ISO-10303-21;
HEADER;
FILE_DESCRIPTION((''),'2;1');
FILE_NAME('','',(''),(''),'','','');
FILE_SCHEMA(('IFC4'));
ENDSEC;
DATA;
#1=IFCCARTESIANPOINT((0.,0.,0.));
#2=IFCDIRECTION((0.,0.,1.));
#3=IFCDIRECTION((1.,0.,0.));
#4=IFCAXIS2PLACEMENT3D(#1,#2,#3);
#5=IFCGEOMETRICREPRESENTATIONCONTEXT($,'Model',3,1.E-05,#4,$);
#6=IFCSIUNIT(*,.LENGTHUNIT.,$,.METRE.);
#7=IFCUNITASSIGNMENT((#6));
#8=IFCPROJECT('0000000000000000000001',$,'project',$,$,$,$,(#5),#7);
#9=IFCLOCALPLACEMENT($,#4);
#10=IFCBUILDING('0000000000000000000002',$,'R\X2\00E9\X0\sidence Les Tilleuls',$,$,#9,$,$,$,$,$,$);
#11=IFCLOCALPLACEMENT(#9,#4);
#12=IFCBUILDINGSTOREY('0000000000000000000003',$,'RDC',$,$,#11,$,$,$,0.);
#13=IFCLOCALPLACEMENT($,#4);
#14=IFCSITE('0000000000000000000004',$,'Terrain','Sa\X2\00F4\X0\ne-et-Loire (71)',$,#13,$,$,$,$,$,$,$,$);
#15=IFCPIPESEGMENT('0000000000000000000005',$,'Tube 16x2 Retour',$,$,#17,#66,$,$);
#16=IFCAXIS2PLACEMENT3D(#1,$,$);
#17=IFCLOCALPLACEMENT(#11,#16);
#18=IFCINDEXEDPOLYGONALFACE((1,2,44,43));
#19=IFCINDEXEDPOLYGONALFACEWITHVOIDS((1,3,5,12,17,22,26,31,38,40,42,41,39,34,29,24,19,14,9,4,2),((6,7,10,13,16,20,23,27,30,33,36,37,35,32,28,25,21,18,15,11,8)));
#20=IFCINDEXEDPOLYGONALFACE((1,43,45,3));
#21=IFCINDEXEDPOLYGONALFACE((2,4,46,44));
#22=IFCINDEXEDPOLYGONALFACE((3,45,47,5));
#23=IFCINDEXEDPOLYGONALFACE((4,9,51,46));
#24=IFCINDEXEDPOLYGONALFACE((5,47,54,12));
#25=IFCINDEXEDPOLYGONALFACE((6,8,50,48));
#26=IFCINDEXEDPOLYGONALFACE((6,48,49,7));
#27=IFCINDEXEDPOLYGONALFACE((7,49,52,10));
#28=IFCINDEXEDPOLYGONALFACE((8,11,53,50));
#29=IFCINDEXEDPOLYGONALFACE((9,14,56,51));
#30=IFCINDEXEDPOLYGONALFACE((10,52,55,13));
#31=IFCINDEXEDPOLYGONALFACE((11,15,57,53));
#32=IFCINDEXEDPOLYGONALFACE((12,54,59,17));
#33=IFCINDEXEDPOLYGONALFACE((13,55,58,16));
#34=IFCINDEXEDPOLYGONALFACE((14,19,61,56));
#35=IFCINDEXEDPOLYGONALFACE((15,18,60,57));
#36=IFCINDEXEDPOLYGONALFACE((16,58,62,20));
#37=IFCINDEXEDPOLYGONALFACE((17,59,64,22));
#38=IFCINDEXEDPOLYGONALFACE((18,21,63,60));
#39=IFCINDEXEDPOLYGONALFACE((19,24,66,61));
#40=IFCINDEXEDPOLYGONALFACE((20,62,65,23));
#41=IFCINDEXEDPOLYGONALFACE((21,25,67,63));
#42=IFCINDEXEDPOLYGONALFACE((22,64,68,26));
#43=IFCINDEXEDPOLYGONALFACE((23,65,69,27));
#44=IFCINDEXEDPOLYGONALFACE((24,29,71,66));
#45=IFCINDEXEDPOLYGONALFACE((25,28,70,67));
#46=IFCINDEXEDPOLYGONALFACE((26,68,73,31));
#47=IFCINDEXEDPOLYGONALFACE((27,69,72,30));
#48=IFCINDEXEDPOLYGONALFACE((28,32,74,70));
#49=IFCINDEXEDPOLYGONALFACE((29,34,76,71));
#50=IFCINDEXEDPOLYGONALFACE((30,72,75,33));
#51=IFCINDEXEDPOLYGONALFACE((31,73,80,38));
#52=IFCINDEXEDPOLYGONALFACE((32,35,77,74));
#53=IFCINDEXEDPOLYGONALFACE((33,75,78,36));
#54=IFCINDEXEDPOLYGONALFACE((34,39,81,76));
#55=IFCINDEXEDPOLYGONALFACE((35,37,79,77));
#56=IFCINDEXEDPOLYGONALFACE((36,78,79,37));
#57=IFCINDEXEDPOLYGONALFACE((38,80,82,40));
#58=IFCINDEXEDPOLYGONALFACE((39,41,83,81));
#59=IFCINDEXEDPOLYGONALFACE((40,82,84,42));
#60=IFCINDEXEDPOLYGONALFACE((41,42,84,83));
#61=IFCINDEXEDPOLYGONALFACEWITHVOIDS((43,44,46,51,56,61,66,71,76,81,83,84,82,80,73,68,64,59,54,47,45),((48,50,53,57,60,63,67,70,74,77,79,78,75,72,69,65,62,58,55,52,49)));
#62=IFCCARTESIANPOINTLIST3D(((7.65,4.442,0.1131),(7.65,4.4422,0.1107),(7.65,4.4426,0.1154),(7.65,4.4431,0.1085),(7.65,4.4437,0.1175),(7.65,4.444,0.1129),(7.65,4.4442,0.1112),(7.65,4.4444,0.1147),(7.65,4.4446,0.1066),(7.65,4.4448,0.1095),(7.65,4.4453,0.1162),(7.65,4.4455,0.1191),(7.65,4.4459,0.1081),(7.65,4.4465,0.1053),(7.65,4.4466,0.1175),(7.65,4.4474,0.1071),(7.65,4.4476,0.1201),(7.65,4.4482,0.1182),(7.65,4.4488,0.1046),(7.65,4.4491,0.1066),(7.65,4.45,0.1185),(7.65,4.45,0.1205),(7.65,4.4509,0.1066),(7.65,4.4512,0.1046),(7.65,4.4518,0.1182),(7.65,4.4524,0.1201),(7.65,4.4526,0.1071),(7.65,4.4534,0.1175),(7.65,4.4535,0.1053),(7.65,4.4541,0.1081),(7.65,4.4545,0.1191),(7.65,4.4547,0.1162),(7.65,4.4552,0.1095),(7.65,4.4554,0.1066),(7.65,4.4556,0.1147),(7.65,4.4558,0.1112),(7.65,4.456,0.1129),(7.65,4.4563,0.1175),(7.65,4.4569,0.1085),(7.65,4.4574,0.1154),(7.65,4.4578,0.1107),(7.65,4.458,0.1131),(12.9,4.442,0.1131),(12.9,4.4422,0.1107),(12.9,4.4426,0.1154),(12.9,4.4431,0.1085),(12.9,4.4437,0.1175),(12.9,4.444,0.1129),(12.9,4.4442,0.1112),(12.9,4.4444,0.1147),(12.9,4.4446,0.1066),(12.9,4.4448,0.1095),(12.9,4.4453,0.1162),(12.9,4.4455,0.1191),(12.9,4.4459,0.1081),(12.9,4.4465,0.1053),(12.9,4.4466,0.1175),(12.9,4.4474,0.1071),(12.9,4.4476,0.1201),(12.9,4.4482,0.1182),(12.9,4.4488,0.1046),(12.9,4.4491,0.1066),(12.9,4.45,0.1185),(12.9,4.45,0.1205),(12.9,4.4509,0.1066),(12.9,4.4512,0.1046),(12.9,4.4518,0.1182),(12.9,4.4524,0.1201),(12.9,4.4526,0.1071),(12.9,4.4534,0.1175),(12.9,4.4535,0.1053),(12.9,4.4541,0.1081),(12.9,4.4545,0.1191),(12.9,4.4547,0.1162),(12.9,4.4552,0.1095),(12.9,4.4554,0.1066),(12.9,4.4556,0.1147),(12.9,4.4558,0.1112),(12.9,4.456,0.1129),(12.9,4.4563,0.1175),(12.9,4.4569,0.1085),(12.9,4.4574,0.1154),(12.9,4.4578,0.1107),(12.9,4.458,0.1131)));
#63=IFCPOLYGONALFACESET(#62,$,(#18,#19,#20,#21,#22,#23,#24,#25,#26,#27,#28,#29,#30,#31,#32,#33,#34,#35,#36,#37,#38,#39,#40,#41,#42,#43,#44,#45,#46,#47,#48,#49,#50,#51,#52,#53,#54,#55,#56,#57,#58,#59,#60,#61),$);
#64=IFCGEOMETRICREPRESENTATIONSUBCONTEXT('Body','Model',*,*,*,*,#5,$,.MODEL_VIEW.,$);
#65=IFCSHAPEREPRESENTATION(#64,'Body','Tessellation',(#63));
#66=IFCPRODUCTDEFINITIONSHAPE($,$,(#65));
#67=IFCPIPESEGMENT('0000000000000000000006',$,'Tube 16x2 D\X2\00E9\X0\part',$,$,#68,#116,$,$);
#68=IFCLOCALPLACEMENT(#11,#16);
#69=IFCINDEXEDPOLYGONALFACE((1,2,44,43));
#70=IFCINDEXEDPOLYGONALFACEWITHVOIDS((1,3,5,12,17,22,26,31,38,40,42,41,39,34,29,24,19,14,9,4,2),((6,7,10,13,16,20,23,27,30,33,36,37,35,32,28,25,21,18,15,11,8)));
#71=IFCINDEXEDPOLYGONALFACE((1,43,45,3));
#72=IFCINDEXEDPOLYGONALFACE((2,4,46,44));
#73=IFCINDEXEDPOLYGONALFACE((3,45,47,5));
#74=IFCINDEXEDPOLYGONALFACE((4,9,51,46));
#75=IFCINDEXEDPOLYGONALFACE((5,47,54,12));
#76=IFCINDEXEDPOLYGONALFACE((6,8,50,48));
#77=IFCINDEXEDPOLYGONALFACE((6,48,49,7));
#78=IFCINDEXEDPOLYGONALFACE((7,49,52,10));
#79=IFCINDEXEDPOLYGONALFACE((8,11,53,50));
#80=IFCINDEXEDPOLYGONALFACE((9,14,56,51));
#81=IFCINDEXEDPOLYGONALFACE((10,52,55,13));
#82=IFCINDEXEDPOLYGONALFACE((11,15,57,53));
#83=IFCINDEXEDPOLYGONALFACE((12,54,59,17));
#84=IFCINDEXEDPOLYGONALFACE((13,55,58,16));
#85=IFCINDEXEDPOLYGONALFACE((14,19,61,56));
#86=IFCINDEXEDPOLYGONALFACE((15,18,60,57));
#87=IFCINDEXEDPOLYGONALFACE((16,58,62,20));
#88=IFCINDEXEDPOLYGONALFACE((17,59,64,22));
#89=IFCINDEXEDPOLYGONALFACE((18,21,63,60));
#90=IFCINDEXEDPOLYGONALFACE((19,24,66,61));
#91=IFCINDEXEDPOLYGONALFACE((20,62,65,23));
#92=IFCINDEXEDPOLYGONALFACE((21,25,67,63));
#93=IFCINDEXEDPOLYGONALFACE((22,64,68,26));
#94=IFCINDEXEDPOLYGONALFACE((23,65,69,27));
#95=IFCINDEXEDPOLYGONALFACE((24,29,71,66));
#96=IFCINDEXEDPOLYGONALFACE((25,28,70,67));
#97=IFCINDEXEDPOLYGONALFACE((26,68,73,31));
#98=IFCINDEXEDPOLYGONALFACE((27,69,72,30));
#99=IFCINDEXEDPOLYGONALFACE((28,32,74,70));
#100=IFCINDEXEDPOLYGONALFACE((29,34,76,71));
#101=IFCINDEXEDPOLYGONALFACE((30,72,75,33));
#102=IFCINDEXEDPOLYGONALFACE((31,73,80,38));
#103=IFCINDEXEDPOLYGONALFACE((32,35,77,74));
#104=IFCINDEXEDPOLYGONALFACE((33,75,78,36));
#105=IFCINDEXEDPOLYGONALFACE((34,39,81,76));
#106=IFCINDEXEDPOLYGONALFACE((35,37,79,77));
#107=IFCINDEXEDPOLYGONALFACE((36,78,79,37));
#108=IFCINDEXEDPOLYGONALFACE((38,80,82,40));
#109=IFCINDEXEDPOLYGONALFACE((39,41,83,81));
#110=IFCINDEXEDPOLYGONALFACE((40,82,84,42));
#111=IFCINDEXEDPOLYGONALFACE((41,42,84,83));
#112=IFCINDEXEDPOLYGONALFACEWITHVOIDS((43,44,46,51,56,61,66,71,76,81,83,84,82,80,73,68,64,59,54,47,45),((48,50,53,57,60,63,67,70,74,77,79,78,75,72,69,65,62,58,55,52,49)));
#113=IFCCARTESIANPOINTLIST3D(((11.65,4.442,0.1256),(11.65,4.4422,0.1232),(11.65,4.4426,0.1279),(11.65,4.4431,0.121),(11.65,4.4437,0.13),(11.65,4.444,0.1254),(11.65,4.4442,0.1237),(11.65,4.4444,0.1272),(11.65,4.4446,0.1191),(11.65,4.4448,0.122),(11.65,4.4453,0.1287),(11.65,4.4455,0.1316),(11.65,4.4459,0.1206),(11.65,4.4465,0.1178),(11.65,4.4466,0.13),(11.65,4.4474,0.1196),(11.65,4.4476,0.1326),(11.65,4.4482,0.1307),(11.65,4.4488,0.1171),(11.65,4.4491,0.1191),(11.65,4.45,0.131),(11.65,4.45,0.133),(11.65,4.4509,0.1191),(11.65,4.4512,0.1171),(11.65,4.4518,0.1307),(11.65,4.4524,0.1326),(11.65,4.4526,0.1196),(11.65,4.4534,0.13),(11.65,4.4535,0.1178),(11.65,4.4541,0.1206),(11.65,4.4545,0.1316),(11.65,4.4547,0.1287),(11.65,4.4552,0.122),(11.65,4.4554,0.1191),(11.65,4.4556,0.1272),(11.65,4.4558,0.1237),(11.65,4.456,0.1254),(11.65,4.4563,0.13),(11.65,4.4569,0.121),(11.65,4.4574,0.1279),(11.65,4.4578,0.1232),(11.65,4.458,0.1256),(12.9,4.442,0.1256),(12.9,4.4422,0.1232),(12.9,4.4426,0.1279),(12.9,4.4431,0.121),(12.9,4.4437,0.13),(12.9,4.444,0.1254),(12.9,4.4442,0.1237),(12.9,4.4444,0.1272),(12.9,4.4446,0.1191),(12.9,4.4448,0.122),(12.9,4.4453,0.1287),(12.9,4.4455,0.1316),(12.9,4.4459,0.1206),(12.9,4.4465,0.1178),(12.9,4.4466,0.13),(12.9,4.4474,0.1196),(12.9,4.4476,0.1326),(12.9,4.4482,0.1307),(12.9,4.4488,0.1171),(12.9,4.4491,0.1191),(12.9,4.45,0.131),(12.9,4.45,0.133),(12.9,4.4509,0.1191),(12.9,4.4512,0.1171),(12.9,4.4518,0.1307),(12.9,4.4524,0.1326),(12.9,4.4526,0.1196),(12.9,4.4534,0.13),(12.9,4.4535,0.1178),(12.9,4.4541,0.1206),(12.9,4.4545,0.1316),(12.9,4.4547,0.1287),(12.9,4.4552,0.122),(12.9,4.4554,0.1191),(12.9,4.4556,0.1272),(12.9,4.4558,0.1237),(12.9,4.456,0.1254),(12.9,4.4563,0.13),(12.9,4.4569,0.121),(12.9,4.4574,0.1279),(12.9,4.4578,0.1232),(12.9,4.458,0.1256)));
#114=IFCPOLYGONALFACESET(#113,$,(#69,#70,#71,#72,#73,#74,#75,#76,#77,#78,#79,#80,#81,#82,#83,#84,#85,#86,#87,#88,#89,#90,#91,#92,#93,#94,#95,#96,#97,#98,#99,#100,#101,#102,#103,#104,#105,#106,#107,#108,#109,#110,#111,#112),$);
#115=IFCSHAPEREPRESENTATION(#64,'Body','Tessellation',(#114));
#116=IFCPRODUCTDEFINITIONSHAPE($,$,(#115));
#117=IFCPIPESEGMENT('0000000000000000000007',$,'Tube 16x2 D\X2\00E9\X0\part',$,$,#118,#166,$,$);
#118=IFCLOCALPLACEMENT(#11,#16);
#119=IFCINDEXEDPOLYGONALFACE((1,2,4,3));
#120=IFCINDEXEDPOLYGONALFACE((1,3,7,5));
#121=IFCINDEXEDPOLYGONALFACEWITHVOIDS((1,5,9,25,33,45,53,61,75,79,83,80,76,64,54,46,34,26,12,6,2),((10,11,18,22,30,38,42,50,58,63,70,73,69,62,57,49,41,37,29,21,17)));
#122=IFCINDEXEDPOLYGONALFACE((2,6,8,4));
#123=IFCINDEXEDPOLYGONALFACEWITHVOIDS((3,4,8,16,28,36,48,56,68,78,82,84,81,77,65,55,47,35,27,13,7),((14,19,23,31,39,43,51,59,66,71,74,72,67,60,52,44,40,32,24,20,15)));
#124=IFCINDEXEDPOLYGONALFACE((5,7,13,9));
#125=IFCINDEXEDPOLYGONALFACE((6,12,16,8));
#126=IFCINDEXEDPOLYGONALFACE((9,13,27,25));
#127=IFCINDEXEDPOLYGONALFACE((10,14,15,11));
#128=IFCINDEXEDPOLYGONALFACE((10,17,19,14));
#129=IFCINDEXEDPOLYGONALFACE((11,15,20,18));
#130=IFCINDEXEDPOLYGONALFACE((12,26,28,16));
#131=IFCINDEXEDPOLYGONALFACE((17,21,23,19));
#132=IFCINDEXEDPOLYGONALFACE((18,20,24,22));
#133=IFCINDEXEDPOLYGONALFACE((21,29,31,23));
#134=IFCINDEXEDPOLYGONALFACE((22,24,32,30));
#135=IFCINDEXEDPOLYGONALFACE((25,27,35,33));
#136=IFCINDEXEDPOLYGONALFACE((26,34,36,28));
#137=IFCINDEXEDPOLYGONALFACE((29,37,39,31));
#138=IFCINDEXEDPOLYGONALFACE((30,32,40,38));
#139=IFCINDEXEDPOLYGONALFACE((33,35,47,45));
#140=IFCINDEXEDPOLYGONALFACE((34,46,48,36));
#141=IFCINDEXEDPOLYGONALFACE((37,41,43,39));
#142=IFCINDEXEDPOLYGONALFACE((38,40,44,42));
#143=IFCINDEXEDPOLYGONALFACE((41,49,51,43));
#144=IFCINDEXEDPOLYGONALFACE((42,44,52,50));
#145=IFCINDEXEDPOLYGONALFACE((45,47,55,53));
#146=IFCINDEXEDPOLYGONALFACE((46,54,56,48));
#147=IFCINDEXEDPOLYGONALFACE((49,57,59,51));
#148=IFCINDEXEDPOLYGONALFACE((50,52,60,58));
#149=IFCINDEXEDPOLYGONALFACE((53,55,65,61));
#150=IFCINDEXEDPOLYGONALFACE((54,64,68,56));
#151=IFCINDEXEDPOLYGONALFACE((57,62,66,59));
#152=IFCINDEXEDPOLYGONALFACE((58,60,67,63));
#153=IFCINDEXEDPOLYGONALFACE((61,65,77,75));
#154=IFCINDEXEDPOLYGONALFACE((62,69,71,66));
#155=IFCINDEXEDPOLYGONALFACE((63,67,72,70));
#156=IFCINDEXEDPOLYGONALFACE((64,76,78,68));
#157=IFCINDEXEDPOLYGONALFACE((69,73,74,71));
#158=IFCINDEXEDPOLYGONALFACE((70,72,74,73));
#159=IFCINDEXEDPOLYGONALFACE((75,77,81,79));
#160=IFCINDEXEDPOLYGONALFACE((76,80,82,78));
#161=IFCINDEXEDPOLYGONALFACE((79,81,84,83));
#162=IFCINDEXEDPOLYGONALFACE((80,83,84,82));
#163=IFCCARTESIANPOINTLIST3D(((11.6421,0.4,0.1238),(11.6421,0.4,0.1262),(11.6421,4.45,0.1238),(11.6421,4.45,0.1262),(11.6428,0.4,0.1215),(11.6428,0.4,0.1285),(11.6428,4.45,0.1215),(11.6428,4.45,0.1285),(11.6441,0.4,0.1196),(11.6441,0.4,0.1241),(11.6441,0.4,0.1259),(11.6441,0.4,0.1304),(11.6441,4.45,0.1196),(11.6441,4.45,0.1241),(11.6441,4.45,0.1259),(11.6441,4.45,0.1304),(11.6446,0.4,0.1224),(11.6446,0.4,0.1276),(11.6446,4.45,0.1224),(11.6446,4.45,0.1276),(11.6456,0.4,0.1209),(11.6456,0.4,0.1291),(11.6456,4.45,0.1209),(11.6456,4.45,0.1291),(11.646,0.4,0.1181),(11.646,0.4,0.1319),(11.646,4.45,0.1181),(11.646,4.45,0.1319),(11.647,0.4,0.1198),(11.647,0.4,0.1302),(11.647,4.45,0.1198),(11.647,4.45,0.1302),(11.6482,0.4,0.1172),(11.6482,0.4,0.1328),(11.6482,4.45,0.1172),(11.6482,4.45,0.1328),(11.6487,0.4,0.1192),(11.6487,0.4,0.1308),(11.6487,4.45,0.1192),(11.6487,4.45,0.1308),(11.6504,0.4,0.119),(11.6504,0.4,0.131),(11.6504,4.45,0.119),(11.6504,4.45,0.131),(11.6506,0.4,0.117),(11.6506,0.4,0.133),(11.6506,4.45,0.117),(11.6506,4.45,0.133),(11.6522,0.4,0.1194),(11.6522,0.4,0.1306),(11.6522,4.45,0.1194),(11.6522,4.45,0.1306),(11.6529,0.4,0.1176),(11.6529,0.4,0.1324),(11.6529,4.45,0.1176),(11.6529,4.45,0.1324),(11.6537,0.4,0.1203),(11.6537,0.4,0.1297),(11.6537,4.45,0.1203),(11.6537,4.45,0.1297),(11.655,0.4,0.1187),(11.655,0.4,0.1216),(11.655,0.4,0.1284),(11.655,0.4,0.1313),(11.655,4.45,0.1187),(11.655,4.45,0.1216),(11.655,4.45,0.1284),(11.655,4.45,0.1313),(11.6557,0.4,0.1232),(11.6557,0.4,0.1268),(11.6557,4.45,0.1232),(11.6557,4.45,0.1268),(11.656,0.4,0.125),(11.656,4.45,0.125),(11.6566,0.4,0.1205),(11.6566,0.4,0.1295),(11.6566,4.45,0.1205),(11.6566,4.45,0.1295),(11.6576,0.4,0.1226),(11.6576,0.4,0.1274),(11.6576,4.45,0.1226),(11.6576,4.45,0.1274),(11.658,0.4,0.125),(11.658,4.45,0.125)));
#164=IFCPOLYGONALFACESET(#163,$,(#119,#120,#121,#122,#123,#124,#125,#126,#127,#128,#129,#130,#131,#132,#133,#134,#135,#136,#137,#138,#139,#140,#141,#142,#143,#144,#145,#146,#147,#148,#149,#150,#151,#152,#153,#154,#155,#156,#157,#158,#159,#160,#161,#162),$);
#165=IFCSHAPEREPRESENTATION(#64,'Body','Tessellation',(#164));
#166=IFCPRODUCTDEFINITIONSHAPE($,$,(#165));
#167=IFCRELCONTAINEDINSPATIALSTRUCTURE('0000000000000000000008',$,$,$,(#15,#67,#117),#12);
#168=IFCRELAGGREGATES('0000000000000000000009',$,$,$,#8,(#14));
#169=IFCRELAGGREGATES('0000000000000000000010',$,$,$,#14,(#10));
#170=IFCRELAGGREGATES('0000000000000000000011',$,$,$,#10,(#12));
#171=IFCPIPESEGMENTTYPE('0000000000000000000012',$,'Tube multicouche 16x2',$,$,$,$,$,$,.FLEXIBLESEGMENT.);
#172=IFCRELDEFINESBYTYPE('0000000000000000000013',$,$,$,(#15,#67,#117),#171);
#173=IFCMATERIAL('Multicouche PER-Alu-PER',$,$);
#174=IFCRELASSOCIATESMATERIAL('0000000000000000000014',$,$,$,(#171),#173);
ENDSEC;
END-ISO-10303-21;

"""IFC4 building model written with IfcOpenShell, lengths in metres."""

from ifc_helpers import new_model, si_unit, frame, origin_with_axes, place, context, subcontext, project, spatial, hollow_circle, extrude, material, type_object, element, save


model = new_model("IFC4")

# Units and contexts
model_context = context("Model", 3, precision=1e-05, world=origin_with_axes())
body_context = subcontext(model_context, "Body", "Model", "MODEL_VIEW")
ifc_project = project(units=[si_unit("LENGTHUNIT", "METRE")], contexts=[model_context])

# Site, building, storey
site_placement = place(None, origin_with_axes())
site = spatial("IfcSite", under=ifc_project, at=site_placement, Name="Terrain", Description="Saône-et-Loire (71)")
building_placement = place(None, origin_with_axes())
building = spatial("IfcBuilding", under=site, at=building_placement, Name="Résidence Les Tilleuls")
storey_placement = place(building_placement, origin_with_axes())
storey = spatial("IfcBuildingStorey", under=building, at=storey_placement, Name="RDC", Elevation=0.0)

# Pipe segments
ifc_material = material(Name="Multicouche PER-Alu-PER")
pipe_segment_type_1 = type_object("IfcPipeSegmentType", Name="Tube multicouche 16x2", PredefinedType="FLEXIBLESEGMENT", material=ifc_material)
pipe_segment_1_placement = place(storey_placement, frame((12.9, 4.45, 0.1125), z_axis=(-1.0, 0.0, 0.0), x_axis=(0.0, 0.0, 1.0)))
element("IfcPipeSegment", 1, at=pipe_segment_1_placement, inside=storey, type_object=pipe_segment_type_1, Name="Tube 16x2 Retour", context=body_context, shape_type="SweptSolid", body=[
    extrude(hollow_circle(Radius=0.008, WallThickness=0.002), origin_with_axes(), (0.0, 0.0, 1.0), 5.25),
])
pipe_segment_2_placement = place(storey_placement, frame((12.9, 4.45, 0.125), z_axis=(-1.0, 0.0, 0.0), x_axis=(0.0, 0.0, 1.0)))
element("IfcPipeSegment", 2, at=pipe_segment_2_placement, inside=storey, type_object=pipe_segment_type_1, Name="Tube 16x2 Départ", context=body_context, shape_type="SweptSolid", body=[
    extrude(hollow_circle(Radius=0.008, WallThickness=0.002), origin_with_axes(), (0.0, 0.0, 1.0), 1.25),
])
pipe_segment_3_placement = place(storey_placement, frame((11.65, 4.45, 0.125), z_axis=(0.0, -1.0, 0.0), x_axis=(1.0, 0.0, 0.0)))
element("IfcPipeSegment", 3, at=pipe_segment_3_placement, inside=storey, type_object=pipe_segment_type_1, Name="Tube 16x2 Départ", context=body_context, shape_type="SweptSolid", body=[
    extrude(hollow_circle(Radius=0.008, WallThickness=0.002), origin_with_axes(), (0.0, 0.0, 1.0), 4.05),
])

save(model, "model.ifc")
